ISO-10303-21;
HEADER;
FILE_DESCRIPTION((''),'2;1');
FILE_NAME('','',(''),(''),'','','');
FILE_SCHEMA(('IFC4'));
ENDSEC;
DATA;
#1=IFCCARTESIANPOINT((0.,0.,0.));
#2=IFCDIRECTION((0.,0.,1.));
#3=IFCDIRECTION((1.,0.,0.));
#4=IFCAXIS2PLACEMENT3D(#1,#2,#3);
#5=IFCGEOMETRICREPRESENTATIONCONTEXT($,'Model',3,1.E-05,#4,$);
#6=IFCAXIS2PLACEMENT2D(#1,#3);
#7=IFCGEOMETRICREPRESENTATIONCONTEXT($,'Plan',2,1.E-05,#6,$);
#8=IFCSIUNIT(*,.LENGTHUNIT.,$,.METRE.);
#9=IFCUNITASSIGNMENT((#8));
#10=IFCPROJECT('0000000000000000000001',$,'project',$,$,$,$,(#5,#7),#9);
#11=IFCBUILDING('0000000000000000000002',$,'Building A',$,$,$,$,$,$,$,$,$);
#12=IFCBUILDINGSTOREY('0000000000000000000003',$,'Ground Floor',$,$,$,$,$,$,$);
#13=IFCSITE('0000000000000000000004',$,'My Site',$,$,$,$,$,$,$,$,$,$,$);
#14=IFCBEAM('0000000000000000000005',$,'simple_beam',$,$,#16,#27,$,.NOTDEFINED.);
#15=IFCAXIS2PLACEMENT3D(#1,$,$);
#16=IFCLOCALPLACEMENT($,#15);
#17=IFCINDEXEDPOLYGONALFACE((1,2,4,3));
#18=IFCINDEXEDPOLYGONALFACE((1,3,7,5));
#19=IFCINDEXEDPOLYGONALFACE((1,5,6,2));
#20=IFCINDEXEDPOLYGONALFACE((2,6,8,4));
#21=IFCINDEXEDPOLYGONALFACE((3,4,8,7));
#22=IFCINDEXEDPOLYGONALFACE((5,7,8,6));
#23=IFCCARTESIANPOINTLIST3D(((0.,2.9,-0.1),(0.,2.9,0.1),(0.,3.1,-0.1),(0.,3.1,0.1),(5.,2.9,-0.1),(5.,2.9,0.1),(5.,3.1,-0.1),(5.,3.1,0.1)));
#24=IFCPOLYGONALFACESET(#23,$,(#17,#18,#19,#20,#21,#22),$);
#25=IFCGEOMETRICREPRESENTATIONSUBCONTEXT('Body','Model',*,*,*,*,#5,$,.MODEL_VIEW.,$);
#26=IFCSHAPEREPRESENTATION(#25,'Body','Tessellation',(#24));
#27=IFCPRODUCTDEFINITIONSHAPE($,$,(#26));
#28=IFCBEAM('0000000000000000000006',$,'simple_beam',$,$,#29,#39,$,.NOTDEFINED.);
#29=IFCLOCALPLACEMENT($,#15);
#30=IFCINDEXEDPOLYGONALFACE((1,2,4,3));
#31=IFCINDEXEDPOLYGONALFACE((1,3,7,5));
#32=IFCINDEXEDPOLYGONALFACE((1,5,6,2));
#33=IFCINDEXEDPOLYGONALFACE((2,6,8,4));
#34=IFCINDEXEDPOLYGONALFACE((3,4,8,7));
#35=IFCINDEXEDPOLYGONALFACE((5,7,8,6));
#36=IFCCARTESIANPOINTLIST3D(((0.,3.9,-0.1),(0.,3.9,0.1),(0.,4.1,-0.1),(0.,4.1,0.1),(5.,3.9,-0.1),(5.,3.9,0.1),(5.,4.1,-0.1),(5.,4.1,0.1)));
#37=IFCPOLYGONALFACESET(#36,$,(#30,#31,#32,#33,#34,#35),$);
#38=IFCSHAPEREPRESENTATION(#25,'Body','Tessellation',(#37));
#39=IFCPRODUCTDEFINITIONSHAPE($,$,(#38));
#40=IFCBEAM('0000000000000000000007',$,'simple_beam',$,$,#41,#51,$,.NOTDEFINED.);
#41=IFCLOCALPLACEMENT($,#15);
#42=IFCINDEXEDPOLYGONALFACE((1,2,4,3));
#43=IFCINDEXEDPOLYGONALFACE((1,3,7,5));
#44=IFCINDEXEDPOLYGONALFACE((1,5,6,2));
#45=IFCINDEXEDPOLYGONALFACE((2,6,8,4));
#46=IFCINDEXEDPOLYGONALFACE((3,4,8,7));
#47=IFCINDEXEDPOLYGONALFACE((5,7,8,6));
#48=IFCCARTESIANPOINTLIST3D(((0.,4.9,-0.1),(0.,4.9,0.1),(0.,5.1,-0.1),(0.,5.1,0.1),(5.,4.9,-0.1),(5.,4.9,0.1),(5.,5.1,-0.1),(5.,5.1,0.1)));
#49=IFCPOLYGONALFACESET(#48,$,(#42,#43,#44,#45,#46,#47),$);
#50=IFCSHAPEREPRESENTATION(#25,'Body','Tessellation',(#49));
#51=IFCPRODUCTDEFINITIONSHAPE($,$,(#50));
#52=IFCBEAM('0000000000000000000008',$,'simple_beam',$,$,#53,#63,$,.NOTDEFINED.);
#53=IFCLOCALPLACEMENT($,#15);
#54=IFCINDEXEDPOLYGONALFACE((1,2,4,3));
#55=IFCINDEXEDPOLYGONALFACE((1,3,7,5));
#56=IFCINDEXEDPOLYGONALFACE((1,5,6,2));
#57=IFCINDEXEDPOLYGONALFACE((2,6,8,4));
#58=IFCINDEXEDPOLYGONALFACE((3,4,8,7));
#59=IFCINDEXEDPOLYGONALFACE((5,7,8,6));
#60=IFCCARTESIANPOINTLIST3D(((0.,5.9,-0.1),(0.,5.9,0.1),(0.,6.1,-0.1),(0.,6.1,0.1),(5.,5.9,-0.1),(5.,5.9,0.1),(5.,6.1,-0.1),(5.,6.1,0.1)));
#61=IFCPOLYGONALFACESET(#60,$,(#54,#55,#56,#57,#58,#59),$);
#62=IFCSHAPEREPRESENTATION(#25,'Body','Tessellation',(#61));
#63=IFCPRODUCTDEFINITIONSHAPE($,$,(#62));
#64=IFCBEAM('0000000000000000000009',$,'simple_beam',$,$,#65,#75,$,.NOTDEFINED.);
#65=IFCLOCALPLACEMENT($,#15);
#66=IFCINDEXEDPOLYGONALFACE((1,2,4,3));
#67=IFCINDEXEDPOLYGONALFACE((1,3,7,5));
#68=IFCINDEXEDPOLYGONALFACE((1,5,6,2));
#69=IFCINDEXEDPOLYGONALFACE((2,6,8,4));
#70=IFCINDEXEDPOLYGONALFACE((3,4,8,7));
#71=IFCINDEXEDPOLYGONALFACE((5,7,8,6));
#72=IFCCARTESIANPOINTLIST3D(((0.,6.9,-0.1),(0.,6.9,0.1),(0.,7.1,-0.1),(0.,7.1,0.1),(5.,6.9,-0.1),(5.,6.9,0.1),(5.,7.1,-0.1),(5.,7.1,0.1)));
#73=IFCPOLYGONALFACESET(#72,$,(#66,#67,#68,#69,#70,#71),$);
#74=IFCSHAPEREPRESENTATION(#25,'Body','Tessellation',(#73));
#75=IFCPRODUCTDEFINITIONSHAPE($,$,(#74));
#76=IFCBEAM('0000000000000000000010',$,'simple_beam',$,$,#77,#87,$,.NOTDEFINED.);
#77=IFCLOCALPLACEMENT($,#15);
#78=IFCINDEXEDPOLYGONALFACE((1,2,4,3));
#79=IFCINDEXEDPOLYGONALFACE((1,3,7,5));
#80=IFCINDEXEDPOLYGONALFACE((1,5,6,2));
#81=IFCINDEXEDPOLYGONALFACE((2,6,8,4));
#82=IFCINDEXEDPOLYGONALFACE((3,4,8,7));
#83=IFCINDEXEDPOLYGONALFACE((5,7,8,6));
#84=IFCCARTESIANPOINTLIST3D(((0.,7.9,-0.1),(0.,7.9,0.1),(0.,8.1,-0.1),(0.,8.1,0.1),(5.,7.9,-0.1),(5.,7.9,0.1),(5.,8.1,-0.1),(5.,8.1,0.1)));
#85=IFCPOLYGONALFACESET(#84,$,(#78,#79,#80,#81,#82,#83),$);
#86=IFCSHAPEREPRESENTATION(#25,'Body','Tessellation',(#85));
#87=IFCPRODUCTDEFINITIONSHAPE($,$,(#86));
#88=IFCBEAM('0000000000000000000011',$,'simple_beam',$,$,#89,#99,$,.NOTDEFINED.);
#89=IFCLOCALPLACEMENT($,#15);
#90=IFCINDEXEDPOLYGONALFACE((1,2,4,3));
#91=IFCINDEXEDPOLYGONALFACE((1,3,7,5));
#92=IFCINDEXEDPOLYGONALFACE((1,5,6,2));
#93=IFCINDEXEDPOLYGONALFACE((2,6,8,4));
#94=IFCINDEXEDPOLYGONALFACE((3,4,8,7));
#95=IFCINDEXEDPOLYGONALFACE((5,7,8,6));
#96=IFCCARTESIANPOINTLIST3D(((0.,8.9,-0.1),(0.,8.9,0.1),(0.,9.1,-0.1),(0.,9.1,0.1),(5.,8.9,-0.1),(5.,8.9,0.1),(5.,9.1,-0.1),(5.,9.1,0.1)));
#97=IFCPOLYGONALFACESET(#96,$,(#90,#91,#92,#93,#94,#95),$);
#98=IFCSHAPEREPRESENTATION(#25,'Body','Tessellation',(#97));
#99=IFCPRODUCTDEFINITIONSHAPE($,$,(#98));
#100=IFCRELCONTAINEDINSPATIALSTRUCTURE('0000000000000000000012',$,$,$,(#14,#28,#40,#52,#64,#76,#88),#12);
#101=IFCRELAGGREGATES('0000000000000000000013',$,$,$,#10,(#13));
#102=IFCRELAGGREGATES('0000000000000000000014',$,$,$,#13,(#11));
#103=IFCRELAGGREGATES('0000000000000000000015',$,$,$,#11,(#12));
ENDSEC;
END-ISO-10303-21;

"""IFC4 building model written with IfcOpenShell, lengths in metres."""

from ifc_helpers import new_model, si_unit, frame, frame_2d, origin_with_axes, place, context, subcontext, project, spatial, rectangle, extrude, element, save


model = new_model("IFC4")

# Units and contexts
model_context = context("Model", 3, precision=1e-05, world=origin_with_axes())
plan_context = context("Plan", 2, precision=1e-05, world=frame_2d((0.0, 0.0, 0.0), x_axis=(1.0, 0.0, 0.0)))
body_context = subcontext(model_context, "Body", "Model", "MODEL_VIEW")
ifc_project = project(units=[si_unit("LENGTHUNIT", "METRE")], contexts=[model_context, plan_context])

# Site, building, storey
site = spatial("IfcSite", under=ifc_project, Name="My Site")
building = spatial("IfcBuilding", under=site, Name="Building A")
storey = spatial("IfcBuildingStorey", under=building, Name="Ground Floor")

# Beams
for number, where, z_axis, x_axis, name in (
    (1, (0.0, 3.0, 0.0), (1.0, 0.0, 0.0), (0.0, 0.0, 1.0), "simple_beam"),
    (2, (0.0, 4.0, 0.0), (1.0, 0.0, 0.0), (0.0, 0.0, 1.0), "simple_beam"),
    (3, (0.0, 5.0, 0.0), (1.0, 0.0, 0.0), (0.0, 0.0, 1.0), "simple_beam"),
    (4, (0.0, 6.0, 0.0), (1.0, 0.0, 0.0), (0.0, 0.0, 1.0), "simple_beam"),
    (5, (0.0, 7.0, 0.0), (1.0, 0.0, 0.0), (0.0, 0.0, 1.0), "simple_beam"),
    (6, (0.0, 8.0, 0.0), (1.0, 0.0, 0.0), (0.0, 0.0, 1.0), "simple_beam"),
    (7, (0.0, 9.0, 0.0), (1.0, 0.0, 0.0), (0.0, 0.0, 1.0), "simple_beam"),
):
    element("IfcBeam", number, at=place(None, frame(where, z_axis=z_axis, x_axis=x_axis)), inside=storey, Name=name, PredefinedType="NOTDEFINED", context=body_context, shape_type="SweptSolid", body=[
        extrude(rectangle(XDim=0.2, YDim=0.2), origin_with_axes(), (0.0, 0.0, 1.0), 5.0),
    ])

save(model, "model.ifc")
